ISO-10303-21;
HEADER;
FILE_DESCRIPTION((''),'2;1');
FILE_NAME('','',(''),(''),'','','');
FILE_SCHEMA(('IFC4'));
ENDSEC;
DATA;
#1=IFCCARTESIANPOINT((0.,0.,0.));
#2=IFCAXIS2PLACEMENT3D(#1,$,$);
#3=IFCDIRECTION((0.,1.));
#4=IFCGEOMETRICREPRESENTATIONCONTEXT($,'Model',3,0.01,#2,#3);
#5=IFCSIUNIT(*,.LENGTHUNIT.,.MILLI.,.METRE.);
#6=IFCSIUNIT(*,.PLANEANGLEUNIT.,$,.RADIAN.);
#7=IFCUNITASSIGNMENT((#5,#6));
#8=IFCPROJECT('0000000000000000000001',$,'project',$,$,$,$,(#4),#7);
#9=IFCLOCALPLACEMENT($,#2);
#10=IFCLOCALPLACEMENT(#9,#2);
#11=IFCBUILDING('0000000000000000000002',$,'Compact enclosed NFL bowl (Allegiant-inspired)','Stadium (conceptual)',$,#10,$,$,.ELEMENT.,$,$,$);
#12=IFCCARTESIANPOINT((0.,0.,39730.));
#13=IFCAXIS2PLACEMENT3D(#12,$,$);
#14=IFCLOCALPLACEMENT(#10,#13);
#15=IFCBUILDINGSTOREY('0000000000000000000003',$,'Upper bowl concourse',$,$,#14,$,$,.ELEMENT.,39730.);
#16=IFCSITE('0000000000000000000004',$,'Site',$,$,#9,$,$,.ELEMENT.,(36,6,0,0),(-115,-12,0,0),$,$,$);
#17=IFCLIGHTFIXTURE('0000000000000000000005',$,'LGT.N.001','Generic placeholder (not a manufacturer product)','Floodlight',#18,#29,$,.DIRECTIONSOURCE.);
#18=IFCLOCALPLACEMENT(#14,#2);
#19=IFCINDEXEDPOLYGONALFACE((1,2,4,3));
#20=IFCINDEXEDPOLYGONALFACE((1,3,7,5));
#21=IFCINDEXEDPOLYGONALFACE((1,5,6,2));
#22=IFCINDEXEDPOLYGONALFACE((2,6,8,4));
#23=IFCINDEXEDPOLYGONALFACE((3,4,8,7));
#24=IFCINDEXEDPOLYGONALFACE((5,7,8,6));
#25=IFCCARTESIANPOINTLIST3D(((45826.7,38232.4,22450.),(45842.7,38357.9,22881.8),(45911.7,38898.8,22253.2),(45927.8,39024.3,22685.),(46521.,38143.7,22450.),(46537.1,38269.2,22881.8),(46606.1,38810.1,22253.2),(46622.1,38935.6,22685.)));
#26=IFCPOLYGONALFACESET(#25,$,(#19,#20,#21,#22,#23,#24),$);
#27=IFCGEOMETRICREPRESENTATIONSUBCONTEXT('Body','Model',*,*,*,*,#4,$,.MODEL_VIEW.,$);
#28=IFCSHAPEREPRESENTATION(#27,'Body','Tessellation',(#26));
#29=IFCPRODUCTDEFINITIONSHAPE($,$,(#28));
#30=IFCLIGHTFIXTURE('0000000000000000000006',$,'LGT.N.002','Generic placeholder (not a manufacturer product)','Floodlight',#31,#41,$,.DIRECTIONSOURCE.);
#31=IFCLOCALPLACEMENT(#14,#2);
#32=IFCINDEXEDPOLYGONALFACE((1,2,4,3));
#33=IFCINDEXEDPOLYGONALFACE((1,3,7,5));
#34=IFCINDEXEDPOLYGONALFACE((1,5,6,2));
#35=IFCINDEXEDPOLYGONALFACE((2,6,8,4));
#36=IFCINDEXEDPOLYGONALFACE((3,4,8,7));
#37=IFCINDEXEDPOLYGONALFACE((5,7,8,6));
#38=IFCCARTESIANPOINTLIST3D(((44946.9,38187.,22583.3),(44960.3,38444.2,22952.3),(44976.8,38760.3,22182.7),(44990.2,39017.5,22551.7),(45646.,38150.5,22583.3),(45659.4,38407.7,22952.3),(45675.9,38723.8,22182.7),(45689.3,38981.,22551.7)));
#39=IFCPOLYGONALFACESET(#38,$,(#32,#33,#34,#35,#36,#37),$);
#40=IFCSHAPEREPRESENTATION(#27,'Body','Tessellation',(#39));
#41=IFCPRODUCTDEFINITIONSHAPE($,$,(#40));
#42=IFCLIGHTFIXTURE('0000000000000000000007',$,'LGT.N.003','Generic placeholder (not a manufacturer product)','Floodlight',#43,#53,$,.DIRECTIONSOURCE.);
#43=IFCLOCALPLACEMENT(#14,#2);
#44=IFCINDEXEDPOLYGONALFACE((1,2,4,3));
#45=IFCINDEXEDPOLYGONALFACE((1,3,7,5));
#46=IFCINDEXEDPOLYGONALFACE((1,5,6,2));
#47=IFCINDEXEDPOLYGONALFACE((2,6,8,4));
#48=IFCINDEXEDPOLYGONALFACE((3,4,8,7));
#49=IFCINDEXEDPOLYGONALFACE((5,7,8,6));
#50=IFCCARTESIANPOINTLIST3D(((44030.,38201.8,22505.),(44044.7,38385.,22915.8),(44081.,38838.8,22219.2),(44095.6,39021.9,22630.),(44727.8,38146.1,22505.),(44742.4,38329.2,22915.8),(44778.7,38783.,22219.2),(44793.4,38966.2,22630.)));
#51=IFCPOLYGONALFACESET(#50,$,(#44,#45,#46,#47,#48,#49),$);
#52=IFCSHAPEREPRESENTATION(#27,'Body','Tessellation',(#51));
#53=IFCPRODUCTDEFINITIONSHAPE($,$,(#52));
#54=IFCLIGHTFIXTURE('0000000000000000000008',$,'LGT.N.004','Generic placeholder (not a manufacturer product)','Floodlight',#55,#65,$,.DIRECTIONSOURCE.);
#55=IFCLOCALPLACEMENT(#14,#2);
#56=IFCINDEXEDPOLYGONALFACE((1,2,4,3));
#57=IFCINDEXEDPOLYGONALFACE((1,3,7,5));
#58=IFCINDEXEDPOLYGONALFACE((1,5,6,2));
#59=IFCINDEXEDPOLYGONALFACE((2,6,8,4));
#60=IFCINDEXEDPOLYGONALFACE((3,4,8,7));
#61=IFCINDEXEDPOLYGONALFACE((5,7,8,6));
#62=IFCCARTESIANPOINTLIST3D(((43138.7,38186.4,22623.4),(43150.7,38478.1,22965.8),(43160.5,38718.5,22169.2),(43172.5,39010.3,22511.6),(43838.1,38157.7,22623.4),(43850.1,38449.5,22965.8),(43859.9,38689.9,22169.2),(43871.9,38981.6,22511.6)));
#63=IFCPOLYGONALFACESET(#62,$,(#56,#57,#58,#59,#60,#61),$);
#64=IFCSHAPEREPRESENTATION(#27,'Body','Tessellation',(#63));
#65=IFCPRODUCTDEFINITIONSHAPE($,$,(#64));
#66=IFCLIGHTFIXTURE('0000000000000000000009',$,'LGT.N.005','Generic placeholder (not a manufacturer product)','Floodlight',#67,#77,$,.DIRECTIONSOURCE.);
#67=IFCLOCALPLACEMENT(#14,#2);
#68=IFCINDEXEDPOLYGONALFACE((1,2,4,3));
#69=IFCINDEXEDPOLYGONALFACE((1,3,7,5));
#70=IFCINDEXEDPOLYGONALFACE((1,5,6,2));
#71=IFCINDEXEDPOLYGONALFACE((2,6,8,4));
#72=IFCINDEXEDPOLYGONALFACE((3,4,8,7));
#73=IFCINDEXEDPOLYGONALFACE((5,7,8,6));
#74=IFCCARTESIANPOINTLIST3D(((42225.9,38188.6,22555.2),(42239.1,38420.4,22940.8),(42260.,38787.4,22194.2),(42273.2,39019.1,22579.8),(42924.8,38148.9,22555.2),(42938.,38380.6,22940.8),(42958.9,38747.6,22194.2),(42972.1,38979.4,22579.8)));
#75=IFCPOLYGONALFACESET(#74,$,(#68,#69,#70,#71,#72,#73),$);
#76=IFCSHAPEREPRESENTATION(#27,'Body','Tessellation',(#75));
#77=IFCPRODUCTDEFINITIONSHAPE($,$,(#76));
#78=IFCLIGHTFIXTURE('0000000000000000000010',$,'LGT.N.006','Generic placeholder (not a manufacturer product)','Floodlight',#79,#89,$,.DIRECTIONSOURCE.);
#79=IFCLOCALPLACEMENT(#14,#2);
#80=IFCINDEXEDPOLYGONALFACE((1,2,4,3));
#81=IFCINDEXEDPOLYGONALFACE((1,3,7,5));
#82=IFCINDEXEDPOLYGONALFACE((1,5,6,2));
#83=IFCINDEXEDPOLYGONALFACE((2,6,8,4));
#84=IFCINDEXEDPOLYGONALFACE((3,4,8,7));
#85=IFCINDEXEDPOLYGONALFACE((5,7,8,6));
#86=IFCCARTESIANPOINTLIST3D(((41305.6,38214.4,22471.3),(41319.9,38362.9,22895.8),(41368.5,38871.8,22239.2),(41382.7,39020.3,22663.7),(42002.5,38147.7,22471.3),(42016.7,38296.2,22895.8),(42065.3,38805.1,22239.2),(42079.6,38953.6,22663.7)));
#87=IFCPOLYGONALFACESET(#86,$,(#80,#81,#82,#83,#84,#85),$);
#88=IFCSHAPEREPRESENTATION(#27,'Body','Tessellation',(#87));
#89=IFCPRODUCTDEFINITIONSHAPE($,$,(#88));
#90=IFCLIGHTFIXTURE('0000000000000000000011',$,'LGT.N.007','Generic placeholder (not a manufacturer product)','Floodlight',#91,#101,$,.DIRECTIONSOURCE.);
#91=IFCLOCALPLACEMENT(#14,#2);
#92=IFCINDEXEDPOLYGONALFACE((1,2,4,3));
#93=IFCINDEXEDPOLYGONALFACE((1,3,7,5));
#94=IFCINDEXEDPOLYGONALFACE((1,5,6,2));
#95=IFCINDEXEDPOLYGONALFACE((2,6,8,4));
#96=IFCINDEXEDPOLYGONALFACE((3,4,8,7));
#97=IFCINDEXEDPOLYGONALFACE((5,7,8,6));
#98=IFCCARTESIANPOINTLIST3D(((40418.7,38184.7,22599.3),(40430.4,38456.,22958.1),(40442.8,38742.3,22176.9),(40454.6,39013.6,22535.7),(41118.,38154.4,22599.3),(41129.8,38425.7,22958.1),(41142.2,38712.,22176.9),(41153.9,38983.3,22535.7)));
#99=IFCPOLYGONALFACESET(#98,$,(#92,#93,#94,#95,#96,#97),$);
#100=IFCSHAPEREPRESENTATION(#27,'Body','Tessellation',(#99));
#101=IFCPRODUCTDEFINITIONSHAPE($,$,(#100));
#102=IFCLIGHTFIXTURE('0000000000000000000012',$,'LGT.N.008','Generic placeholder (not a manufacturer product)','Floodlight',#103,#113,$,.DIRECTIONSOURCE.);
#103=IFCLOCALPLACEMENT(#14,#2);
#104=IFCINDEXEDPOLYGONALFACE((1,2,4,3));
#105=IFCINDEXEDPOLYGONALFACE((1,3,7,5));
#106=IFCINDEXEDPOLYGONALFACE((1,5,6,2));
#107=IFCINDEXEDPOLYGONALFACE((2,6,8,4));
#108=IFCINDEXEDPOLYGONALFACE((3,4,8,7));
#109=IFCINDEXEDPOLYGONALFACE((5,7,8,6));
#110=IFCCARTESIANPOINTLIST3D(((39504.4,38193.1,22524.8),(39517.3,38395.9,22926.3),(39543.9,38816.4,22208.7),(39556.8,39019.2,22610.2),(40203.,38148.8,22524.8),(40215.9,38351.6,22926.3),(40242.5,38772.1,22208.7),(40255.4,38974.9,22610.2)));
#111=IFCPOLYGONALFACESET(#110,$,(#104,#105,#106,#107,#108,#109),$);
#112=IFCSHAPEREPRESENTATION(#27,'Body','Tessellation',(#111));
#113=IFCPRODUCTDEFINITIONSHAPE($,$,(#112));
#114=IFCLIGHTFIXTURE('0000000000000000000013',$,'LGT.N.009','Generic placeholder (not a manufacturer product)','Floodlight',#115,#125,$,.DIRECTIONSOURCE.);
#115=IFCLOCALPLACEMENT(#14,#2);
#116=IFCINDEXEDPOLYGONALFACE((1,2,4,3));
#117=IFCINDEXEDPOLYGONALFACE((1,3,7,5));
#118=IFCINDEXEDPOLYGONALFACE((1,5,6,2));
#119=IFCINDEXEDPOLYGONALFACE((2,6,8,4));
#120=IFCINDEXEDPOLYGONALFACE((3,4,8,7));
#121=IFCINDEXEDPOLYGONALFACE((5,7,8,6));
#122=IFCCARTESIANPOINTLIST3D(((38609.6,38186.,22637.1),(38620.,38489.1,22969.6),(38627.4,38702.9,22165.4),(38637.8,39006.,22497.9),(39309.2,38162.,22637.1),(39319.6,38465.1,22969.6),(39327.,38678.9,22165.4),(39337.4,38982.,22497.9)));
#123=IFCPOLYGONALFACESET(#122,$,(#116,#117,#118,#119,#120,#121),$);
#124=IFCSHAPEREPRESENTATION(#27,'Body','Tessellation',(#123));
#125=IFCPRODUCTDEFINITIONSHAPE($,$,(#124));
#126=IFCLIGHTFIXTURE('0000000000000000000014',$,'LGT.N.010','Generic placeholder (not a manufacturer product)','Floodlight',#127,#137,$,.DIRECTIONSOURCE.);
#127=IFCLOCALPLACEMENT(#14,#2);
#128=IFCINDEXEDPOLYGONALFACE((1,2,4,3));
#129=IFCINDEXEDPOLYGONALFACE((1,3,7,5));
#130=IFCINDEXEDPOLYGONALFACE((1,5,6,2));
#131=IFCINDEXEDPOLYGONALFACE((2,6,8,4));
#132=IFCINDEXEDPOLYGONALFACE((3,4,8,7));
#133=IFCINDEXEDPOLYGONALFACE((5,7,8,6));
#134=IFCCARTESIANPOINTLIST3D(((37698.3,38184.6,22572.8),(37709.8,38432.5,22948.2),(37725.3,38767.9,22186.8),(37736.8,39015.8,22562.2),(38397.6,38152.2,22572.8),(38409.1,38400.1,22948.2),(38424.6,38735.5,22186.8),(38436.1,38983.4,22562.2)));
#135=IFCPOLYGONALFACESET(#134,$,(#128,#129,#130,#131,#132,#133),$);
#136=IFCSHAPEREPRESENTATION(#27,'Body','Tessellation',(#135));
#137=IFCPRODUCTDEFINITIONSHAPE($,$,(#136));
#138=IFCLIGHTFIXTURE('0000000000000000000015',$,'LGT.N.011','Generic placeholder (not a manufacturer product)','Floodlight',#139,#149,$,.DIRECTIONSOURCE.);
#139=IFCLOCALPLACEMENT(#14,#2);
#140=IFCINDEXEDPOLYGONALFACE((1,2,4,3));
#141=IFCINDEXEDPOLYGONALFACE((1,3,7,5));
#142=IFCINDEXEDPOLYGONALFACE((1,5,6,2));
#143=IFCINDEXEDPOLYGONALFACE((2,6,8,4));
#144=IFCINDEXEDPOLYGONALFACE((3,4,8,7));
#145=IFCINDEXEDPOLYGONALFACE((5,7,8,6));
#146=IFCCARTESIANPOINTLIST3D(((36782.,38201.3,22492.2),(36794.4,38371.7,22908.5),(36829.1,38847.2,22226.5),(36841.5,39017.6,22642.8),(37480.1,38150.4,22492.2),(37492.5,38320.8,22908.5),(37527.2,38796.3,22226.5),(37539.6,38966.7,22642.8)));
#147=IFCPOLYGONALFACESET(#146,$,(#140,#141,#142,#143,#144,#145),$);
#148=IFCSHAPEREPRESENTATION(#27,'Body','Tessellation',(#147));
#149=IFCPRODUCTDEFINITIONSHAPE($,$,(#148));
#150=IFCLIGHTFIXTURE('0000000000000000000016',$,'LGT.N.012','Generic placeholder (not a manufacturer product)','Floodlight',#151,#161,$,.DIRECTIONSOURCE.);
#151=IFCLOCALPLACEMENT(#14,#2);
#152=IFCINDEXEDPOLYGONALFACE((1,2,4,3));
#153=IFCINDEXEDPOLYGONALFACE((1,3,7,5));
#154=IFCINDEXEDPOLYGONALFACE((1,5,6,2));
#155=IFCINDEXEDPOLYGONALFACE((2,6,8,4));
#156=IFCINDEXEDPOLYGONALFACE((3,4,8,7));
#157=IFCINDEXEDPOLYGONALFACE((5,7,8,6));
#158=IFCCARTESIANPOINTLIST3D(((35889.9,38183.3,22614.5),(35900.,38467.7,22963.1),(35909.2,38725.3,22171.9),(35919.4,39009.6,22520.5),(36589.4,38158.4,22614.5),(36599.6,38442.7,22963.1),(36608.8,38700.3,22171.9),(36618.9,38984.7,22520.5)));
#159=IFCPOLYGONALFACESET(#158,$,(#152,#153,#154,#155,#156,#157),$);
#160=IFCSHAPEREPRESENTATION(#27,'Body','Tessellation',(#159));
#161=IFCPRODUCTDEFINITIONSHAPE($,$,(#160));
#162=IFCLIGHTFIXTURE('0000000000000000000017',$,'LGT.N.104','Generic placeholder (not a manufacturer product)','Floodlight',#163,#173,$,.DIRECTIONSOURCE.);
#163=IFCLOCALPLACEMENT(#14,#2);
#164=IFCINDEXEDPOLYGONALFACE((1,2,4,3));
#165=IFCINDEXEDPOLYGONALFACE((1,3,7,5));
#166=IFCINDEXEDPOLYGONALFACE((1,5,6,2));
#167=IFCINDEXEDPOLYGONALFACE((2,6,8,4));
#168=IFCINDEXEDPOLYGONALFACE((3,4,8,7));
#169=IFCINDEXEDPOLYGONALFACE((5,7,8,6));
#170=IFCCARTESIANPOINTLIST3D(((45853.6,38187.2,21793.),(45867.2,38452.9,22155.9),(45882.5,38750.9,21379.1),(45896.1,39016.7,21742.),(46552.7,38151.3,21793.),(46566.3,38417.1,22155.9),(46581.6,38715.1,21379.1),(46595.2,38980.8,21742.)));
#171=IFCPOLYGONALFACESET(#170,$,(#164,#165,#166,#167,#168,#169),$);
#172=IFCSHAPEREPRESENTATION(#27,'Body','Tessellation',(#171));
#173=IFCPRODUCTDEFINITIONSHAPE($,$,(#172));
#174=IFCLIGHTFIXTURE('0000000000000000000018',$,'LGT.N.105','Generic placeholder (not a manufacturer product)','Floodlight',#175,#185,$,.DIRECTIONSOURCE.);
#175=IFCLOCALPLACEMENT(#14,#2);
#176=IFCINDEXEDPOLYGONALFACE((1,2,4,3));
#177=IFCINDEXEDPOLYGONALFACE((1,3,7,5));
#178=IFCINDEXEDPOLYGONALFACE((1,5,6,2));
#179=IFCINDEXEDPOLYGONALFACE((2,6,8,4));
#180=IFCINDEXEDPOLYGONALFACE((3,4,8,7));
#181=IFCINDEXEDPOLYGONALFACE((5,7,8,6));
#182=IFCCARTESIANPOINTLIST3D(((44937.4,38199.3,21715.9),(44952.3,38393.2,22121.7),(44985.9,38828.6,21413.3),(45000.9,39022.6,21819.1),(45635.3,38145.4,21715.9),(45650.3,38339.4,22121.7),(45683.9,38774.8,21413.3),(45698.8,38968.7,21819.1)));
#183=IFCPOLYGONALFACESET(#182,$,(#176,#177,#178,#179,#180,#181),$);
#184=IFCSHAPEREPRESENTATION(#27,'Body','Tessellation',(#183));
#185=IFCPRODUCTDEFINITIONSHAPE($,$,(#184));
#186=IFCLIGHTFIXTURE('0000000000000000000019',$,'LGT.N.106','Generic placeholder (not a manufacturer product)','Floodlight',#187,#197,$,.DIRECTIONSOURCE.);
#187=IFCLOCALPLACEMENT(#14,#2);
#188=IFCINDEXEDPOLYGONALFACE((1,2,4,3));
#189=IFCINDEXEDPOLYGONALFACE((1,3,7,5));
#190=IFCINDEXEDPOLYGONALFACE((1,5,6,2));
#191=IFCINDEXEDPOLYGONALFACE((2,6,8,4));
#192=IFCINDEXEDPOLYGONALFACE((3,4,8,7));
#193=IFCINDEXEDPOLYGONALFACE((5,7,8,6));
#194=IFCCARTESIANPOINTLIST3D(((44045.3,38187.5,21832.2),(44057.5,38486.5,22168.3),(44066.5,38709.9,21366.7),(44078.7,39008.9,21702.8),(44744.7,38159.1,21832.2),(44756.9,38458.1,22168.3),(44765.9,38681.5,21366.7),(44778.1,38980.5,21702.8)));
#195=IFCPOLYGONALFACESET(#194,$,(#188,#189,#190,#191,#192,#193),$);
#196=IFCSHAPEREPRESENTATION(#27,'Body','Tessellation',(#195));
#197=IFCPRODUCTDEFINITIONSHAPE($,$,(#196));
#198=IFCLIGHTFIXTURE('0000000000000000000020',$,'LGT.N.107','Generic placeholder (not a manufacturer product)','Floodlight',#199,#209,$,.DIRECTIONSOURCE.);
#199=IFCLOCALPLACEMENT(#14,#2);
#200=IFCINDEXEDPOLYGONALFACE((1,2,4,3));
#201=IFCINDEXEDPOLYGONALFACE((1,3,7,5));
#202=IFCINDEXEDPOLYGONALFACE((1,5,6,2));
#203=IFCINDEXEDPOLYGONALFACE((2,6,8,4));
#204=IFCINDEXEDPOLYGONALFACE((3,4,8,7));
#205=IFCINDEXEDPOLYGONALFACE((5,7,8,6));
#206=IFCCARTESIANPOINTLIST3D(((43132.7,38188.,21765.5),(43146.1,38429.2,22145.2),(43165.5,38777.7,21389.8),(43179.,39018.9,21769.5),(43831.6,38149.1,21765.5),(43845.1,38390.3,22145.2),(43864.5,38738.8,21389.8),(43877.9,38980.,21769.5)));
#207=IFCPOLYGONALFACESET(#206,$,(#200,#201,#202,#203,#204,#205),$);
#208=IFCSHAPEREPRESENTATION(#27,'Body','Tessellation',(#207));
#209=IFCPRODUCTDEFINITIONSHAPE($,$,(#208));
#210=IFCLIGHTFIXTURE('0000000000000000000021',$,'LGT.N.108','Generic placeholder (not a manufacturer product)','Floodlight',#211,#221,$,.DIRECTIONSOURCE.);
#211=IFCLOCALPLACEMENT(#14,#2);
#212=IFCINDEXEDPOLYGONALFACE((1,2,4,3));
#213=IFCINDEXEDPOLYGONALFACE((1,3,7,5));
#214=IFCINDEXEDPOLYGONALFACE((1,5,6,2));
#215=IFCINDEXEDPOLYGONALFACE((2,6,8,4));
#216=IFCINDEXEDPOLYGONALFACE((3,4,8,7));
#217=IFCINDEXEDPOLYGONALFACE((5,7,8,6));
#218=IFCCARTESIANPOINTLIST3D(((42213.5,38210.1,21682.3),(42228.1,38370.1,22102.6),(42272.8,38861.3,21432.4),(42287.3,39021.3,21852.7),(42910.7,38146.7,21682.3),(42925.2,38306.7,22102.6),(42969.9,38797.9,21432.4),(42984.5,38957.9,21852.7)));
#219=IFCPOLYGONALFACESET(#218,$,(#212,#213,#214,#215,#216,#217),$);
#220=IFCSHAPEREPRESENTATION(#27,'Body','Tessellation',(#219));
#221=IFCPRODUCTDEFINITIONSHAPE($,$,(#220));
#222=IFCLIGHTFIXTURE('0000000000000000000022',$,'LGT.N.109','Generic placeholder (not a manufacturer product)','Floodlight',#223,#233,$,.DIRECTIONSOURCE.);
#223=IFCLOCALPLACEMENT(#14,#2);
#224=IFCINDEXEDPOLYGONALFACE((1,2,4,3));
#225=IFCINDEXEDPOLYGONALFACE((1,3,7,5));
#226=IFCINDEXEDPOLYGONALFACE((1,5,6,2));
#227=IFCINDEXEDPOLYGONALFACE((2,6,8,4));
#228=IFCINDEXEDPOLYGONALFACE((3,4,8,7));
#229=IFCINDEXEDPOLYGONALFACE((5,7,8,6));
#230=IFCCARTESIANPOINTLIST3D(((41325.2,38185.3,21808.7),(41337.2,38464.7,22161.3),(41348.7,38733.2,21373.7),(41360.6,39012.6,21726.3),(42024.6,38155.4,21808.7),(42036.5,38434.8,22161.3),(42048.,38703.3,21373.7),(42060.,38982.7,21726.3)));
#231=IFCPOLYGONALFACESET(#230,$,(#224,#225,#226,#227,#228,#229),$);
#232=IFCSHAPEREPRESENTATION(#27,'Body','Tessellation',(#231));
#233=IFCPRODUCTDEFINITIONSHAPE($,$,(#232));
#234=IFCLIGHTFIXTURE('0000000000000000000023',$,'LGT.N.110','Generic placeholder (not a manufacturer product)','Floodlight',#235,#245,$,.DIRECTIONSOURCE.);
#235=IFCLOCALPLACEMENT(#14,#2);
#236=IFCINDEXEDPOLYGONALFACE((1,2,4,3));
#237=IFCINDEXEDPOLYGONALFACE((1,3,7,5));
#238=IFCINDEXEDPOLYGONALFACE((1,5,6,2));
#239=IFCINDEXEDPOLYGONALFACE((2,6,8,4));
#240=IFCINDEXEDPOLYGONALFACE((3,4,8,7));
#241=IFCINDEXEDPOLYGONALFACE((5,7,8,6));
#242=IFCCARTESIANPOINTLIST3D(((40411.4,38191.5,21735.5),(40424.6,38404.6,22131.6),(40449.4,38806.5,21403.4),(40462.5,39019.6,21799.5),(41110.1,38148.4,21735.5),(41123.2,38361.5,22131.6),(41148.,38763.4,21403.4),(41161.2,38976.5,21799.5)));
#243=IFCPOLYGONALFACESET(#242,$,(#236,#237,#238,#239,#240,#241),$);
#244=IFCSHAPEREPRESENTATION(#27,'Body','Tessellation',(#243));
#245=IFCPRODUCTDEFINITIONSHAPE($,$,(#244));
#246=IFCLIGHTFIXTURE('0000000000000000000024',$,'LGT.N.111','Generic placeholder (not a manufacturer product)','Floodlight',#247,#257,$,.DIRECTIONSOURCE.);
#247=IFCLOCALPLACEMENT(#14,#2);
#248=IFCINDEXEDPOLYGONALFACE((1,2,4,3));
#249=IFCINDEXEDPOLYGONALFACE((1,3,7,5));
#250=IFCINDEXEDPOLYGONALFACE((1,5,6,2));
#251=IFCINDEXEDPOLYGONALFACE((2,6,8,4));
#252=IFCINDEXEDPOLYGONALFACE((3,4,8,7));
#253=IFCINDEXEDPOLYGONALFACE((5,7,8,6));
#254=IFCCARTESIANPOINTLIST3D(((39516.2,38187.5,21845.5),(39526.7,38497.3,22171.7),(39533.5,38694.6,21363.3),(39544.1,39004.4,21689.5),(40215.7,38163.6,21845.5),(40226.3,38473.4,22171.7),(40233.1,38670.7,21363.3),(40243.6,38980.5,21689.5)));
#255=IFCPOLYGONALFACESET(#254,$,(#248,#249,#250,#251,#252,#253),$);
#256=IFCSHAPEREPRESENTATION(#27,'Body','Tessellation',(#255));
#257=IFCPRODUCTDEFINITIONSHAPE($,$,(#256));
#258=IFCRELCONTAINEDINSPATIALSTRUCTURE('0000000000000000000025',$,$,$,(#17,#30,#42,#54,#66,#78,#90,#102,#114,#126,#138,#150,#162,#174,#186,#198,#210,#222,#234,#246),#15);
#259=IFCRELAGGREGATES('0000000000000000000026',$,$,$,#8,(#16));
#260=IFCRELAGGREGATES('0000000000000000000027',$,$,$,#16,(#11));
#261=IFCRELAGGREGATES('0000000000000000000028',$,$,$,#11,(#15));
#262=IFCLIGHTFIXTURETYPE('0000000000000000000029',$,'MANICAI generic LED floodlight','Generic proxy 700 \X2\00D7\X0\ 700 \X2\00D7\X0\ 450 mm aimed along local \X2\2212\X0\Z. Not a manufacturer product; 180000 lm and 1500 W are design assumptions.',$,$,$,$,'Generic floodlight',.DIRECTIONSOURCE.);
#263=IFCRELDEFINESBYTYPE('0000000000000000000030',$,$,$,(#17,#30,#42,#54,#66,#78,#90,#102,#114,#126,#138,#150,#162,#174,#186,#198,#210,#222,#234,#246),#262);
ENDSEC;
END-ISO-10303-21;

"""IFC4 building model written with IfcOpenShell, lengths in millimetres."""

from ifc_helpers import new_model, si_unit, direction, frame, origin, place, context, subcontext, project, spatial, rectangle, extrude, source, transform, mapped, type_object, type_shapes, element, save


model = new_model("IFC4")

# Units and contexts
model_context = context("Model", 3, precision=0.01, world=origin(), true_north=direction((0.0, 1.0)))
body_context = subcontext(model_context, "Body", "Model", "MODEL_VIEW")
ifc_project = project(units=[si_unit("LENGTHUNIT", "METRE", prefix="MILLI"), si_unit("PLANEANGLEUNIT", "RADIAN")], contexts=[model_context])

# Site, building, storey
site_placement = place(None, origin())
site = spatial("IfcSite", under=ifc_project, at=site_placement, Name="Site", CompositionType="ELEMENT", RefLatitude=(36, 6, 0, 0), RefLongitude=(-115, -12, 0, 0))
building_placement = place(site_placement, origin())
building = spatial("IfcBuilding", under=site, at=building_placement, Name="Compact enclosed NFL bowl (Allegiant-inspired)", Description="Stadium (conceptual)", CompositionType="ELEMENT")
storey_placement = place(building_placement, frame((0.0, 0.0, 39730.0)))
storey = spatial("IfcBuildingStorey", under=building, at=storey_placement, Name="Upper bowl concourse", CompositionType="ELEMENT", Elevation=39730.0)

# Light fixtures
light_fixture_type = type_object("IfcLightFixtureType", Name="MANICAI generic LED floodlight", Description="Generic proxy 700 × 700 × 450 mm aimed along local −Z. Not a manufacturer product; 180000 lm and 1500 W are design assumptions.", ElementType="Generic floodlight", PredefinedType="DIRECTIONSOURCE")
shared_shape = source(origin(), body_context, "Body", "SweptSolid", [
    extrude(rectangle(XDim=700.0, YDim=700.0), frame((0.0, 0.0, -225.0)), (0.0, 0.0, 1.0), 450.0),
])
type_shapes(light_fixture_type, [shared_shape])
for number, where, z_axis, x_axis, name in (
    (1, (46224.4, 38584.0, 22567.5), (0.035604, 0.278848, 0.959675), (-0.991947, 0.126653, 0.0), "LGT.N.001"),
    (2, (45318.1, 38584.0, 22567.5), (0.029827, 0.571537, 0.820034), (-0.998641, 0.052116, 0.0), "LGT.N.002"),
    (3, (44411.7, 38584.0, 22567.5), (0.032539, 0.406954, 0.912869), (-0.996819, 0.079703, 0.0), "LGT.N.003"),
    (4, (43505.3, 38584.0, 22567.5), (0.026567, 0.64839, 0.760844), (-0.999162, 0.040939, 0.0), "LGT.N.004"),
    (5, (42599.0, 38584.0, 22567.5), (0.029292, 0.514923, 0.856736), (-0.998386, 0.056794, 0.0), "LGT.N.005"),
    (6, (41692.6, 38584.0, 22567.5), (0.03157, 0.330066, 0.94343), (-0.995457, 0.095212, 0.0), "LGT.N.006"),
    (7, (40786.3, 38584.0, 22567.5), (0.026101, 0.602985, 0.797325), (-0.999064, 0.043245, 0.0), "LGT.N.007"),
    (8, (39879.9, 38584.0, 22567.5), (0.028558, 0.45066, 0.892239), (-0.997998, 0.063243, 0.0), "LGT.N.008"),
    (9, (38973.5, 38584.0, 22567.5), (0.023112, 0.673464, 0.738859), (-0.999412, 0.034297, 0.0), "LGT.N.009"),
    (10, (38067.2, 38584.0, 22567.5), (0.025488, 0.55085, 0.834215), (-0.998931, 0.04622, 0.0), "LGT.N.010"),
    (11, (37160.8, 38584.0, 22567.5), (0.027594, 0.378536, 0.925175), (-0.997354, 0.072703, 0.0), "LGT.N.011"),
    (12, (36254.4, 38584.0, 22567.5), (0.022544, 0.631856, 0.774758), (-0.999364, 0.035656, 0.0), "LGT.N.012"),
    (13, (46224.4, 38584.0, 21767.5), (0.030307, 0.590562, 0.806423), (-0.998686, 0.051252, 0.0), "LGT.N.104"),
    (14, (45318.1, 38584.0, 21767.5), (0.033226, 0.430942, 0.901768), (-0.997041, 0.076873, 0.0), "LGT.N.105"),
    (15, (44411.7, 38584.0, 21767.5), (0.026969, 0.664408, 0.746883), (-0.999177, 0.040557, 0.0), "LGT.N.106"),
    (16, (43505.3, 38584.0, 21767.5), (0.029845, 0.535899, 0.843754), (-0.998453, 0.055605, 0.0), "LGT.N.107"),
    (17, (42599.0, 38584.0, 21767.5), (0.032352, 0.355602, 0.934077), (-0.995887, 0.090603, 0.0), "LGT.N.108"),
    (18, (41692.6, 38584.0, 21767.5), (0.026559, 0.620831, 0.783494), (-0.999086, 0.04274, 0.0), "LGT.N.109"),
    (19, (40786.3, 38584.0, 21767.5), (0.029191, 0.473549, 0.880284), (-0.998105, 0.061526, 0.0), "LGT.N.110"),
    (20, (39879.9, 38584.0, 21767.5), (0.023505, 0.688422, 0.72493), (-0.999418, 0.034124, 0.0), "LGT.N.111"),
):
    element("IfcLightFixture", number, at=place(storey_placement, frame(where, z_axis=z_axis, x_axis=x_axis)), inside=storey, type_object=light_fixture_type, Name=name, Description="Generic placeholder (not a manufacturer product)", ObjectType="Floodlight", PredefinedType="DIRECTIONSOURCE", context=body_context, shape_type="MappedRepresentation", body=[
        mapped(shared_shape, transform((0.0, 0.0, 0.0))),
    ])

save(model, "model.ifc")
